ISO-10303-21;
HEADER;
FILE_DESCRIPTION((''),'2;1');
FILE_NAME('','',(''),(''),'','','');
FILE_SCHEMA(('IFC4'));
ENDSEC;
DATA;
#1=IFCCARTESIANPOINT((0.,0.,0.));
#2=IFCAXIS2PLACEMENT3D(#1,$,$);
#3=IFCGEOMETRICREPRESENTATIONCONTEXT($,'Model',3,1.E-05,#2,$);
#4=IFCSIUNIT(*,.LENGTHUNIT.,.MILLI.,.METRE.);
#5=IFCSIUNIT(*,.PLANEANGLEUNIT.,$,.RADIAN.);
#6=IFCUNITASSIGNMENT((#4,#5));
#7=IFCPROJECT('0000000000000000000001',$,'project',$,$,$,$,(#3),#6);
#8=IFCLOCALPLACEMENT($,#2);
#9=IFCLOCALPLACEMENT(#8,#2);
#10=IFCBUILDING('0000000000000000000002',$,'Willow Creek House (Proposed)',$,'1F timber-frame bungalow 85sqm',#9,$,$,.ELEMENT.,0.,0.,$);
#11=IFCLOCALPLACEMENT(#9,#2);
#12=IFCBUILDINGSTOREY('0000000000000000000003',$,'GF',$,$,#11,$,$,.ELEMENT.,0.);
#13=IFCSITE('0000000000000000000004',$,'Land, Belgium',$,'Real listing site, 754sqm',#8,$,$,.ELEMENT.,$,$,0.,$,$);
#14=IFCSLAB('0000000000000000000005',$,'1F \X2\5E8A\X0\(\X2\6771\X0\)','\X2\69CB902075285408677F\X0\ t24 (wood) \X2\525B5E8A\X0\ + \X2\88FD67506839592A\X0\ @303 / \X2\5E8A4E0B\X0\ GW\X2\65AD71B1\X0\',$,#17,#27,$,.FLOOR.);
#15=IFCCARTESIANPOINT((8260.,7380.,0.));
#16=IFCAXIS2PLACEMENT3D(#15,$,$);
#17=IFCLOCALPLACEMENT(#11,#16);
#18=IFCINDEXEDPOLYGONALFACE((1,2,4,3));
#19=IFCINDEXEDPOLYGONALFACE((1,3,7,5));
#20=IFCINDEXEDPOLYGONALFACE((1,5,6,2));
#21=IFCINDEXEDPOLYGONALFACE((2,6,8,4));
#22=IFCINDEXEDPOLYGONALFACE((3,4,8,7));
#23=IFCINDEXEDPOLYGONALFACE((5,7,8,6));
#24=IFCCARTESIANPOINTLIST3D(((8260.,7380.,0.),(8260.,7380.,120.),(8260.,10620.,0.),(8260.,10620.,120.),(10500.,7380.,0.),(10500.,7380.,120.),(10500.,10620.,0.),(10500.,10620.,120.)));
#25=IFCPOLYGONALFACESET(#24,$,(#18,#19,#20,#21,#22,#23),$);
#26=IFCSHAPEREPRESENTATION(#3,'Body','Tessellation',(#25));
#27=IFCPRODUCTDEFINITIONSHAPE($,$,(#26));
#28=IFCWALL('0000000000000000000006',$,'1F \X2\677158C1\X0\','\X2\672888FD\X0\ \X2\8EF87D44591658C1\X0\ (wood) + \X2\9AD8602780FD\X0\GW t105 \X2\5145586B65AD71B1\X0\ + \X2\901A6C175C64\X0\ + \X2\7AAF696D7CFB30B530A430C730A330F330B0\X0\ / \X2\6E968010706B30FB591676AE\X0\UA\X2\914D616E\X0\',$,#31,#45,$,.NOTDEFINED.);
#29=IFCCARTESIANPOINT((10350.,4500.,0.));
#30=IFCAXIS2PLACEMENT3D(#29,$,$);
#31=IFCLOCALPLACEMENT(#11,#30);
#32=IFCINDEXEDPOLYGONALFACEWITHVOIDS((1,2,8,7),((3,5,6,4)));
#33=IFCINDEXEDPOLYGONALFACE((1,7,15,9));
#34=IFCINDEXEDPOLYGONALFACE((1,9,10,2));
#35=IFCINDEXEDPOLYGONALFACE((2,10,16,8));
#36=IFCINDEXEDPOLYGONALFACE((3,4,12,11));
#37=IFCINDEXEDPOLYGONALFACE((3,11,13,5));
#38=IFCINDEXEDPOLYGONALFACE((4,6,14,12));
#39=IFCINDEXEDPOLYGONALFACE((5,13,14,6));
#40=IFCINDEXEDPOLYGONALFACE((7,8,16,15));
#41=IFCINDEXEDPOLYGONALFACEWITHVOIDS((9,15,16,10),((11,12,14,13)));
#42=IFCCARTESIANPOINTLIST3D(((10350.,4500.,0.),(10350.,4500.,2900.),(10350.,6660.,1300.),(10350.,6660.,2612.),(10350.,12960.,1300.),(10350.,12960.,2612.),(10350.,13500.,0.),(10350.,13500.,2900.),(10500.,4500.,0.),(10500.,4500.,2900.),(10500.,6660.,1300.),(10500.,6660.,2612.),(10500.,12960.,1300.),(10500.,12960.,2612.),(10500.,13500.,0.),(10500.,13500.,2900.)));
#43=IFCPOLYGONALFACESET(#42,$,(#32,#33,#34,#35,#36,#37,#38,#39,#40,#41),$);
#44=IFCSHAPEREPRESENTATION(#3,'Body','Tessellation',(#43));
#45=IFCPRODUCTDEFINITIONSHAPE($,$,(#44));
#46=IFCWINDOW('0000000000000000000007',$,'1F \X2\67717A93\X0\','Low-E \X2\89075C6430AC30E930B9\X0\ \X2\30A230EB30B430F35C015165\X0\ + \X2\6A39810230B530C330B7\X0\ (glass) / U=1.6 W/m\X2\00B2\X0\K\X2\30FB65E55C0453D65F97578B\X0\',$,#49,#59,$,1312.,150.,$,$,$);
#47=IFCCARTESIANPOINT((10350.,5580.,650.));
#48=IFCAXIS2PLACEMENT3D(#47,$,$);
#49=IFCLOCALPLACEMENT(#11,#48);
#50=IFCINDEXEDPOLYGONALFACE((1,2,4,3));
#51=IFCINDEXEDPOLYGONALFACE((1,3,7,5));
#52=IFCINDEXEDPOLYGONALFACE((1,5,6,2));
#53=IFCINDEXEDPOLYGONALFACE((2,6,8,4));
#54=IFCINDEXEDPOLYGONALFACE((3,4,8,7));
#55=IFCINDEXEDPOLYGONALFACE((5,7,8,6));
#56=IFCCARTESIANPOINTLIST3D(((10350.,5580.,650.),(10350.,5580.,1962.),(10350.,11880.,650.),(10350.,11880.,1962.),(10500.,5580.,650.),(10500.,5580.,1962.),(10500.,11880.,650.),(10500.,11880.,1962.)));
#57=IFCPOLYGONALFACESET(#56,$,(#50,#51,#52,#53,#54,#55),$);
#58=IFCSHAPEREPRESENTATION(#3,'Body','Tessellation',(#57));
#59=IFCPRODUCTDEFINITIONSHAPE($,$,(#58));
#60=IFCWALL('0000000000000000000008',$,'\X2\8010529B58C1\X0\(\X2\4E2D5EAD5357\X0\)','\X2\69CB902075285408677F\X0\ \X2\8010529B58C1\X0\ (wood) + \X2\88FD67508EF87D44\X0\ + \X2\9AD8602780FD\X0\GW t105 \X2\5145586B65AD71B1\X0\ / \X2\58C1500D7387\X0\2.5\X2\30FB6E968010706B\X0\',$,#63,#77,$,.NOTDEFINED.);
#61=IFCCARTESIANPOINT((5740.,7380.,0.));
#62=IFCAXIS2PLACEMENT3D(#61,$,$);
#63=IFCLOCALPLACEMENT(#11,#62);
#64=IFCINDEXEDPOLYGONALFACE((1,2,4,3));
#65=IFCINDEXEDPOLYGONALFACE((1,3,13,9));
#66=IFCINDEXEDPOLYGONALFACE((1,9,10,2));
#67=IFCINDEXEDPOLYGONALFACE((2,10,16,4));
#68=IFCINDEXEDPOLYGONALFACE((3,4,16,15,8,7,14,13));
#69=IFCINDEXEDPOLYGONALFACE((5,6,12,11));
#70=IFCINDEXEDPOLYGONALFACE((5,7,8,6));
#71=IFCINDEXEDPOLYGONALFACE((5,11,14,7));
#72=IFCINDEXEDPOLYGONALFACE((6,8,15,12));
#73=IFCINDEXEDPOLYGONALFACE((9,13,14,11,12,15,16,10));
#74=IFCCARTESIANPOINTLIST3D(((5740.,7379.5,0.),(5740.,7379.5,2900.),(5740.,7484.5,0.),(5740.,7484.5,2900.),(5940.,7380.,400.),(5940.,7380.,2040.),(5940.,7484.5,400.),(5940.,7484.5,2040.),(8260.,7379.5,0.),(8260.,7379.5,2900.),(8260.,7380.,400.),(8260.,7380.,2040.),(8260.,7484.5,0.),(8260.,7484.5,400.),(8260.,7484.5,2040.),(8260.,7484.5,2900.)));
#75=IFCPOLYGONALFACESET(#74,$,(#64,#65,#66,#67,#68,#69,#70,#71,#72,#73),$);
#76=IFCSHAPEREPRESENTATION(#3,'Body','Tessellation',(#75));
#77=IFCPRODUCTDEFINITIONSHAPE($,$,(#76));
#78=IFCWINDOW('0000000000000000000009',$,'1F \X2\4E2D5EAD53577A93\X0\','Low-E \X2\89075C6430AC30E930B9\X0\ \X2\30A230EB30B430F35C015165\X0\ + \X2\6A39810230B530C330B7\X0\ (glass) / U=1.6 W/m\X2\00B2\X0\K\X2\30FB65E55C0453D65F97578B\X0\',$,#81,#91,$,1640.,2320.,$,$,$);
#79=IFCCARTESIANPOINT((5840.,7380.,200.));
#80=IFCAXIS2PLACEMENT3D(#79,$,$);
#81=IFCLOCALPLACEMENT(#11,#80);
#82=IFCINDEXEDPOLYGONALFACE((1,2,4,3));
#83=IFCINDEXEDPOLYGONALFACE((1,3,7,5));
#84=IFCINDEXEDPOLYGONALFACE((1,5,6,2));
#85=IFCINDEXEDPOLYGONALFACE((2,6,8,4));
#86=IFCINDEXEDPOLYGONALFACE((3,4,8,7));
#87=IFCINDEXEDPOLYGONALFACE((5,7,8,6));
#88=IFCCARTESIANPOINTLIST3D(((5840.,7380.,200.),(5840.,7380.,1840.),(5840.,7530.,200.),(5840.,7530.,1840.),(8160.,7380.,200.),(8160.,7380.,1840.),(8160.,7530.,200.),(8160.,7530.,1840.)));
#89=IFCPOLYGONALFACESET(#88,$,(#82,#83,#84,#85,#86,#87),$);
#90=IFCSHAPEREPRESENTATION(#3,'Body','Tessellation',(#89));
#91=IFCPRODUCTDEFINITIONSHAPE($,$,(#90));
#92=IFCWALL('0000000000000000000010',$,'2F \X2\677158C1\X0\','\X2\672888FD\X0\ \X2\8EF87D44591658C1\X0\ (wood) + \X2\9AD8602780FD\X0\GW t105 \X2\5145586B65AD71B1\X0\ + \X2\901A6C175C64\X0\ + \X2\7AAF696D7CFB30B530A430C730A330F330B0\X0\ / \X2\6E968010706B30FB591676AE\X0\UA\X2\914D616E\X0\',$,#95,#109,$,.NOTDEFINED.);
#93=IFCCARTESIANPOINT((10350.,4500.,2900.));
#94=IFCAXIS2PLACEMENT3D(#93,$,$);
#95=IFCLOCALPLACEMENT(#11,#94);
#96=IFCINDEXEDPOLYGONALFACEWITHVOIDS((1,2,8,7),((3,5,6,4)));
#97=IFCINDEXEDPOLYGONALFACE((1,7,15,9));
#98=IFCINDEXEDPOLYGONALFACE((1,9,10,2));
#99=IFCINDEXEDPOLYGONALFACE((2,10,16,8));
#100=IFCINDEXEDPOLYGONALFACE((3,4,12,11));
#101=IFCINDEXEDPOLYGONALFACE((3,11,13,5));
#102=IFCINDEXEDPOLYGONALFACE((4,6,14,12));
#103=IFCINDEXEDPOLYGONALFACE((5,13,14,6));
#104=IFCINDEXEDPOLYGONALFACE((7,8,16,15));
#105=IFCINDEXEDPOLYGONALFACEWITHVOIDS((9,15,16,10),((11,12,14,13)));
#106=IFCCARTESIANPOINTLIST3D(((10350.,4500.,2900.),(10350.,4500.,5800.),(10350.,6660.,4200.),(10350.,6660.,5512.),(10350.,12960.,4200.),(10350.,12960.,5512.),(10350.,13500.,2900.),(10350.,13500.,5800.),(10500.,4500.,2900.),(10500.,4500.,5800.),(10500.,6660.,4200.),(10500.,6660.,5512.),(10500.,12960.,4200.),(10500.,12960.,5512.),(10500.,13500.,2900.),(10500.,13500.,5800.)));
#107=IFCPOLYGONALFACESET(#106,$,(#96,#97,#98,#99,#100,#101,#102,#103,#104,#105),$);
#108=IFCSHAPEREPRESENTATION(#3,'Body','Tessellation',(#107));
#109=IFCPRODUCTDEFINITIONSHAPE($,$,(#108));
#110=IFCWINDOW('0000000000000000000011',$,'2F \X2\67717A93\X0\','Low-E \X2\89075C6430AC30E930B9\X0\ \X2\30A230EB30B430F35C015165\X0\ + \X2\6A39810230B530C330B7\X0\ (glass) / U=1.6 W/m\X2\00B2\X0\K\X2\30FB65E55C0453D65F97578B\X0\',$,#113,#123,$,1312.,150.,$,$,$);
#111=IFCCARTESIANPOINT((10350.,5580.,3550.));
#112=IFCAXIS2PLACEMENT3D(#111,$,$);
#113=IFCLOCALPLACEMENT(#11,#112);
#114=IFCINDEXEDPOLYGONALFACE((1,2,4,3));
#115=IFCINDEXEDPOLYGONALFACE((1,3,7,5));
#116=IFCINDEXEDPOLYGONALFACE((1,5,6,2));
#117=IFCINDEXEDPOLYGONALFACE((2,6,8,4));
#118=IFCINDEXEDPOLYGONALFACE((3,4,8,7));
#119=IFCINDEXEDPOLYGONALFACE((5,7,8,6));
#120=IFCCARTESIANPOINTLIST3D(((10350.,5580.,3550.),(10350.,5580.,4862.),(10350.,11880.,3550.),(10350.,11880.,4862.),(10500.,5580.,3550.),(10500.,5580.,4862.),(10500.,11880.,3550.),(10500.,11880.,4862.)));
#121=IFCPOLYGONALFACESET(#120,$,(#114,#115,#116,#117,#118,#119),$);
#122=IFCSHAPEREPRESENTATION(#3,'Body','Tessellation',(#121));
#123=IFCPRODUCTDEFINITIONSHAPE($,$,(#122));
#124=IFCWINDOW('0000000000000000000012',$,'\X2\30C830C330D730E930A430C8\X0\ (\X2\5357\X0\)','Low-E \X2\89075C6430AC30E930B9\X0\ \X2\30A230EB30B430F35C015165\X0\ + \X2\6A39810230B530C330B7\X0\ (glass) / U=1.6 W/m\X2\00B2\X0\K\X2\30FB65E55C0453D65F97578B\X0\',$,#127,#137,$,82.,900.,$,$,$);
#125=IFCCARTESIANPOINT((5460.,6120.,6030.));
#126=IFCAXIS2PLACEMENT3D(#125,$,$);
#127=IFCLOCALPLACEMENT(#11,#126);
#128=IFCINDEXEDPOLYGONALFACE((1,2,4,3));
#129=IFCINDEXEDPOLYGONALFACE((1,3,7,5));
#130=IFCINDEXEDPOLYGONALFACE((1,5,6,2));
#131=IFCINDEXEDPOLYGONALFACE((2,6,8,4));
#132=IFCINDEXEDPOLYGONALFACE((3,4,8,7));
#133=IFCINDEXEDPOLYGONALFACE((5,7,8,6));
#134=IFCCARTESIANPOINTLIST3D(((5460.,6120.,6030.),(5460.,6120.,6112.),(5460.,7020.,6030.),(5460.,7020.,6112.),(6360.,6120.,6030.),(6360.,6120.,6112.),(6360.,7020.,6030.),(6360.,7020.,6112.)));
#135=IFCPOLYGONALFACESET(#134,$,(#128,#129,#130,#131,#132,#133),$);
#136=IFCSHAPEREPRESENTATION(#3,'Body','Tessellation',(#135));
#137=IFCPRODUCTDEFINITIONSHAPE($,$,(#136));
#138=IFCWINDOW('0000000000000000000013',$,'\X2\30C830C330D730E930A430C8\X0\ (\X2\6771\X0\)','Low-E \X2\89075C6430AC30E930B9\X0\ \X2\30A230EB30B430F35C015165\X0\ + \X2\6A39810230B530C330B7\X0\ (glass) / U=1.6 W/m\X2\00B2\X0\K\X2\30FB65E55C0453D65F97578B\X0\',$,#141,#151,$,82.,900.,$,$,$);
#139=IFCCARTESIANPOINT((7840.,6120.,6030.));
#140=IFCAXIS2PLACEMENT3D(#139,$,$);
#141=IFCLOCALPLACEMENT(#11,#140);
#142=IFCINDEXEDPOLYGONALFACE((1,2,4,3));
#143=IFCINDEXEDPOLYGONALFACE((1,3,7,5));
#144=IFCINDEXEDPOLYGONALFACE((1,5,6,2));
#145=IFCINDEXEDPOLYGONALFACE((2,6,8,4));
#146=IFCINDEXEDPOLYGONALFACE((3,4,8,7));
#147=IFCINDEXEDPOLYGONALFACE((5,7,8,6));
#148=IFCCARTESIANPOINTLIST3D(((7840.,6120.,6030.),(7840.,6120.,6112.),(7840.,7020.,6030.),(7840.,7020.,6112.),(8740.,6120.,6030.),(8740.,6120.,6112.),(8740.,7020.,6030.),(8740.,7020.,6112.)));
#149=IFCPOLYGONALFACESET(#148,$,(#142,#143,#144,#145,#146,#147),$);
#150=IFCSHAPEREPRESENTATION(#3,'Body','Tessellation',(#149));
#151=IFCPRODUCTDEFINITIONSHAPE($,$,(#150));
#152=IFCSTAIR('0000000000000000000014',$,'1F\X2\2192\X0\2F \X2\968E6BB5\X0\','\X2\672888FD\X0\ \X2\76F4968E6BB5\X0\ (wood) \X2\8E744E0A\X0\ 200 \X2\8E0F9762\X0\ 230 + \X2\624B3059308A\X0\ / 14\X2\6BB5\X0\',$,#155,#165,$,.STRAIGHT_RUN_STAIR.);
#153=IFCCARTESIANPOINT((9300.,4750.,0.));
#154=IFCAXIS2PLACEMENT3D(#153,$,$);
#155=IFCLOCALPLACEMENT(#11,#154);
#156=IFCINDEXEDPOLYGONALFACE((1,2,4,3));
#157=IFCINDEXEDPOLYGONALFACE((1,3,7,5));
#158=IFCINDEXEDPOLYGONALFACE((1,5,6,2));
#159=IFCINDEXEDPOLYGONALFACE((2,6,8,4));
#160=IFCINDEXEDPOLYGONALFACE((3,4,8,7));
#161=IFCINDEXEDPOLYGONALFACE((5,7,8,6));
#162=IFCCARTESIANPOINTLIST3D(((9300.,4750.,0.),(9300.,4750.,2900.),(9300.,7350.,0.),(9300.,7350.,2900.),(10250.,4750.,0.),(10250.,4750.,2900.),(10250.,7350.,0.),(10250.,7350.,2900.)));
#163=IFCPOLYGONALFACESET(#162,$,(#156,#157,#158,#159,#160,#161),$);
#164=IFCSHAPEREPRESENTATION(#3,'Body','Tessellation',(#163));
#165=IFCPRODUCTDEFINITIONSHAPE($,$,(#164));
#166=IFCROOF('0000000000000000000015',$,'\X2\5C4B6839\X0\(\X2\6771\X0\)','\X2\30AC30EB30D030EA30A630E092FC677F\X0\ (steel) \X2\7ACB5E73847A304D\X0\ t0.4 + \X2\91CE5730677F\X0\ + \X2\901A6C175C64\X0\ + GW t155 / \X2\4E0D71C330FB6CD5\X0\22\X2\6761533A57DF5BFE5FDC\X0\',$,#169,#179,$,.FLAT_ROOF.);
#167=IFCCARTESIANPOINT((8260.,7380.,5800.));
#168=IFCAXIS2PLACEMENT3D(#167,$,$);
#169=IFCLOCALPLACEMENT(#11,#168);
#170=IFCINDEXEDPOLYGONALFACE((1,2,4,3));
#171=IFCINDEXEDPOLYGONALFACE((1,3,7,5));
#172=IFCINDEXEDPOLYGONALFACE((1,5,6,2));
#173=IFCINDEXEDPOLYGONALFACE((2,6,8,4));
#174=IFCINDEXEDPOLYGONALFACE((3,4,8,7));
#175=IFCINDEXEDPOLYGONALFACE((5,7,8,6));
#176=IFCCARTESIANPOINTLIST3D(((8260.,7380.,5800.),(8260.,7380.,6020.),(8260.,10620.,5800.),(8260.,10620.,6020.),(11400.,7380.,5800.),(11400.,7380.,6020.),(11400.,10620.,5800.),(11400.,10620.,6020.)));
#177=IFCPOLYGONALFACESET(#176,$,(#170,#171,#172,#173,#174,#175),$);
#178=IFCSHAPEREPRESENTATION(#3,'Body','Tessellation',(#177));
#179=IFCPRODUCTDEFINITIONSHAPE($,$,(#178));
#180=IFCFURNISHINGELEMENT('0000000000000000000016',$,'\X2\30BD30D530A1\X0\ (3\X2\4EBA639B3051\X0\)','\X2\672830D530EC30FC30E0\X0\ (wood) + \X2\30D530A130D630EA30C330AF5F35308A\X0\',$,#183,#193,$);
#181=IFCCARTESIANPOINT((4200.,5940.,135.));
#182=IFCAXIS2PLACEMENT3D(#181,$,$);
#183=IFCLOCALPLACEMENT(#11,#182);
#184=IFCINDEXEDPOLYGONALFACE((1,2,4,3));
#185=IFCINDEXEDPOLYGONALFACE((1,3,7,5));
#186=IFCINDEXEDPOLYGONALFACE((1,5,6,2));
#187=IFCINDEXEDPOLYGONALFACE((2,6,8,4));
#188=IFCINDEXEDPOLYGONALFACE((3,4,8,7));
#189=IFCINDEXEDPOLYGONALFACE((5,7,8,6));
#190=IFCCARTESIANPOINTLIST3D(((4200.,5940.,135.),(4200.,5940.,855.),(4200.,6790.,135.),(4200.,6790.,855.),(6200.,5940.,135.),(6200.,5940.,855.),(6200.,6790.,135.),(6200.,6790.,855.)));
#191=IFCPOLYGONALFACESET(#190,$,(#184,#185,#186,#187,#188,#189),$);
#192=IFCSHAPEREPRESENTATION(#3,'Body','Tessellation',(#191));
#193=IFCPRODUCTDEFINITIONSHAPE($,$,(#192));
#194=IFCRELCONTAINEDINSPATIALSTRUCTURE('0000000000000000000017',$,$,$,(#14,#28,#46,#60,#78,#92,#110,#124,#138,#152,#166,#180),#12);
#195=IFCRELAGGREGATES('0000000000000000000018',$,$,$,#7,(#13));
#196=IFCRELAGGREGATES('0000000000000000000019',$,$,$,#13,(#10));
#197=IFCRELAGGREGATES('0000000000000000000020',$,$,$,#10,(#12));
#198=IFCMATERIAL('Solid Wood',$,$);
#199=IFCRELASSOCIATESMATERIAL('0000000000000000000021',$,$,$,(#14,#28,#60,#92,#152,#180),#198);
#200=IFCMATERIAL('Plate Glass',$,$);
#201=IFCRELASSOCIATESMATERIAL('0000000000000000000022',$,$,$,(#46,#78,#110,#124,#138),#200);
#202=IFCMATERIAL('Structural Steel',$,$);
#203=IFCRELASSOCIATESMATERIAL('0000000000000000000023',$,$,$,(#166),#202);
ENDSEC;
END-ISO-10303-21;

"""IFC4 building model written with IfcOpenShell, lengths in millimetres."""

from ifc_helpers import new_model, si_unit, frame, frame_2d, origin, place, context, project, spatial, rectangle, extrude, material, element, fill, save


model = new_model("IFC4")

# Units and contexts
model_context = context("Model", 3, precision=1e-05, world=origin())
ifc_project = project(units=[si_unit("LENGTHUNIT", "METRE", prefix="MILLI"), si_unit("PLANEANGLEUNIT", "RADIAN")], contexts=[model_context])

# Site, building, storey
site_placement = place(None, origin())
site = spatial("IfcSite", under=ifc_project, at=site_placement, Name="Land, Belgium", ObjectType="Real listing site, 754sqm", CompositionType="ELEMENT", RefElevation=0.0)
building_placement = place(site_placement, origin())
building = spatial("IfcBuilding", under=site, at=building_placement, Name="Willow Creek House (Proposed)", ObjectType="1F timber-frame bungalow 85sqm", CompositionType="ELEMENT", ElevationOfRefHeight=0.0, ElevationOfTerrain=0.0)
storey_placement = place(building_placement, origin())
storey = spatial("IfcBuildingStorey", under=building, at=storey_placement, Name="GF", CompositionType="ELEMENT", Elevation=0.0)

# Slab
ifc_material_1 = material(Name="Solid Wood")
slab_placement = place(storey_placement, frame((8260.0, 7380.0, 0.0)))
element("IfcSlab", 1, at=slab_placement, inside=storey, material=ifc_material_1, Name="1F 床(東)", Description="構造用合板 t24 (wood) 剛床 + 製材根太 @303 / 床下 GW断熱", PredefinedType="FLOOR", context=model_context, shape_type="SweptSolid", body=[
    extrude(rectangle(XDim=2240.0, YDim=3240.0, at=frame_2d((1120.0, 1620.0))), frame((8260.0, 7380.0, 0.0)), (0.0, 0.0, 1.0), 120.0),
])

# Walls, openings, windows
wall_1_placement = place(storey_placement, frame((10350.0, 4500.0, 0.0)))
wall_1 = element("IfcWall", 2, at=wall_1_placement, inside=storey, material=ifc_material_1, Name="1F 東壁", Description="木製 軸組外壁 (wood) + 高性能GW t105 充填断熱 + 通気層 + 窯業系サイディング / 準耐火・外皮UA配慮", PredefinedType="NOTDEFINED", context=model_context, shape_type="SweptSolid", body=[
    extrude(rectangle(XDim=150.0, YDim=9000.0, at=frame_2d((75.0, 4500.0))), frame((10350.0, 4500.0, 0.0)), (0.0, 0.0, 1.0), 2900.0),
])
opening_1_placement = place(storey_placement, frame((10350.0, 5580.0, 650.0)))
opening_1 = element("IfcOpeningElement", 3, at=opening_1_placement, cuts=wall_1, PredefinedType="NOTDEFINED", context=model_context, shape_type="SweptSolid", body=[
    extrude(rectangle(XDim=150.0, YDim=6300.0, at=frame_2d((75.0, 3150.0))), frame((10350.0, 5580.0, 650.0)), (0.0, 0.0, 1.0), 1312.0),
])
ifc_material_2 = material(Name="Plate Glass")
window_1_placement = place(storey_placement, frame((10350.0, 5580.0, 650.0)))
window_1 = element("IfcWindow", 4, at=window_1_placement, inside=storey, material=ifc_material_2, Name="1F 東窓", Description="Low-E 複層ガラス アルゴン封入 + 樹脂サッシ (glass) / U=1.6 W/m²K・日射取得型", OverallHeight=1312.0, OverallWidth=150.0, context=model_context, shape_type="SweptSolid", body=[
    extrude(rectangle(XDim=150.0, YDim=6300.0, at=frame_2d((75.0, 3150.0))), frame((10350.0, 5580.0, 650.0)), (0.0, 0.0, 1.0), 1312.0),
])
fill(opening_1, window_1)
wall_2_placement = place(storey_placement, frame((5740.0, 7380.0, 0.0)))
wall_2 = element("IfcWall", 5, at=wall_2_placement, inside=storey, material=ifc_material_1, Name="耐力壁(中庭南)", Description="構造用合板 耐力壁 (wood) + 製材軸組 + 高性能GW t105 充填断熱 / 壁倍率2.5・準耐火", PredefinedType="NOTDEFINED", context=model_context, shape_type="SweptSolid", body=[
    extrude(rectangle(XDim=2520.0, YDim=105.0, at=frame_2d((1260.0, 52.0))), frame((5740.0, 7380.0, 0.0)), (0.0, 0.0, 1.0), 2900.0),
])
opening_2_placement = place(storey_placement, frame((5840.0, 7380.0, 200.0)))
opening_2 = element("IfcOpeningElement", 6, at=opening_2_placement, cuts=wall_2, PredefinedType="NOTDEFINED", context=model_context, shape_type="SweptSolid", body=[
    extrude(rectangle(XDim=2320.0, YDim=150.0, at=frame_2d((1160.0, 75.0))), frame((5840.0, 7380.0, 200.0)), (0.0, 0.0, 1.0), 1640.0),
])
window_2_placement = place(storey_placement, frame((5840.0, 7380.0, 200.0)))
window_2 = element("IfcWindow", 7, at=window_2_placement, inside=storey, material=ifc_material_2, Name="1F 中庭南窓", Description="Low-E 複層ガラス アルゴン封入 + 樹脂サッシ (glass) / U=1.6 W/m²K・日射取得型", OverallHeight=1640.0, OverallWidth=2320.0, context=model_context, shape_type="SweptSolid", body=[
    extrude(rectangle(XDim=2320.0, YDim=150.0, at=frame_2d((1160.0, 75.0))), frame((5840.0, 7380.0, 200.0)), (0.0, 0.0, 1.0), 1640.0),
])
fill(opening_2, window_2)

# Wall, opening, window
wall_3_placement = place(storey_placement, frame((10350.0, 4500.0, 2900.0)))
wall_3 = element("IfcWall", 8, at=wall_3_placement, inside=storey, material=ifc_material_1, Name="2F 東壁", Description="木製 軸組外壁 (wood) + 高性能GW t105 充填断熱 + 通気層 + 窯業系サイディング / 準耐火・外皮UA配慮", PredefinedType="NOTDEFINED", context=model_context, shape_type="SweptSolid", body=[
    extrude(rectangle(XDim=150.0, YDim=9000.0, at=frame_2d((75.0, 4500.0))), frame((10350.0, 4500.0, 2900.0)), (0.0, 0.0, 1.0), 2900.0),
])
opening_3_placement = place(storey_placement, frame((10350.0, 5580.0, 3550.0)))
opening_3 = element("IfcOpeningElement", 9, at=opening_3_placement, cuts=wall_3, PredefinedType="NOTDEFINED", context=model_context, shape_type="SweptSolid", body=[
    extrude(rectangle(XDim=150.0, YDim=6300.0, at=frame_2d((75.0, 3150.0))), frame((10350.0, 5580.0, 3550.0)), (0.0, 0.0, 1.0), 1312.0),
])
window_3_placement = place(storey_placement, frame((10350.0, 5580.0, 3550.0)))
window_3 = element("IfcWindow", 10, at=window_3_placement, inside=storey, material=ifc_material_2, Name="2F 東窓", Description="Low-E 複層ガラス アルゴン封入 + 樹脂サッシ (glass) / U=1.6 W/m²K・日射取得型", OverallHeight=1312.0, OverallWidth=150.0, context=model_context, shape_type="SweptSolid", body=[
    extrude(rectangle(XDim=150.0, YDim=6300.0, at=frame_2d((75.0, 3150.0))), frame((10350.0, 5580.0, 3550.0)), (0.0, 0.0, 1.0), 1312.0),
])
fill(opening_3, window_3)

# Windows
window_4_placement = place(storey_placement, frame((5460.0, 6120.0, 6030.0)))
element("IfcWindow", 11, at=window_4_placement, inside=storey, material=ifc_material_2, Name="トップライト (南)", Description="Low-E 複層ガラス アルゴン封入 + 樹脂サッシ (glass) / U=1.6 W/m²K・日射取得型", OverallHeight=82.0, OverallWidth=900.0, context=model_context, shape_type="SweptSolid", body=[
    extrude(rectangle(XDim=900.0, YDim=900.0, at=frame_2d((450.0, 450.0))), frame((5460.0, 6120.0, 6030.0)), (0.0, 0.0, 1.0), 82.0),
])
window_5_placement = place(storey_placement, frame((7840.0, 6120.0, 6030.0)))
element("IfcWindow", 12, at=window_5_placement, inside=storey, material=ifc_material_2, Name="トップライト (東)", Description="Low-E 複層ガラス アルゴン封入 + 樹脂サッシ (glass) / U=1.6 W/m²K・日射取得型", OverallHeight=82.0, OverallWidth=900.0, context=model_context, shape_type="SweptSolid", body=[
    extrude(rectangle(XDim=900.0, YDim=900.0, at=frame_2d((450.0, 450.0))), frame((7840.0, 6120.0, 6030.0)), (0.0, 0.0, 1.0), 82.0),
])

# Stair
stair_placement = place(storey_placement, frame((9300.0, 4750.0, 0.0)))
element("IfcStair", 13, at=stair_placement, inside=storey, material=ifc_material_1, Name="1F→2F 階段", Description="木製 直階段 (wood) 蹴上 200 踏面 230 + 手すり / 14段", PredefinedType="STRAIGHT_RUN_STAIR", context=model_context, shape_type="SweptSolid", body=[
    extrude(rectangle(XDim=950.0, YDim=2600.0, at=frame_2d((475.0, 1300.0))), frame((9300.0, 4750.0, 0.0)), (0.0, 0.0, 1.0), 2900.0),
])

# Roof
ifc_material_3 = material(Name="Structural Steel")
roof_placement = place(storey_placement, frame((8260.0, 7380.0, 5800.0)))
element("IfcRoof", 14, at=roof_placement, inside=storey, material=ifc_material_3, Name="屋根(東)", Description="ガルバリウム鋼板 (steel) 立平葺き t0.4 + 野地板 + 通気層 + GW t155 / 不燃・法22条区域対応", PredefinedType="FLAT_ROOF", context=model_context, shape_type="SweptSolid", body=[
    extrude(rectangle(XDim=3140.0, YDim=3240.0, at=frame_2d((1570.0, 1620.0))), frame((8260.0, 7380.0, 5800.0)), (0.0, 0.0, 1.0), 220.0),
])

# Furnishing element
furnishing_1_placement = place(storey_placement, frame((4200.0, 5940.0, 135.0)))
element("IfcFurnishingElement", 15, at=furnishing_1_placement, inside=storey, material=ifc_material_1, Name="ソファ (3人掛け)", Description="木フレーム (wood) + ファブリック張り", context=model_context, shape_type="SweptSolid", body=[
    extrude(rectangle(XDim=2000.0, YDim=850.0, at=frame_2d((1000.0, 425.0))), frame((4200.0, 5940.0, 135.0)), (0.0, 0.0, 1.0), 720.0),
])

save(model, "model.ifc")
